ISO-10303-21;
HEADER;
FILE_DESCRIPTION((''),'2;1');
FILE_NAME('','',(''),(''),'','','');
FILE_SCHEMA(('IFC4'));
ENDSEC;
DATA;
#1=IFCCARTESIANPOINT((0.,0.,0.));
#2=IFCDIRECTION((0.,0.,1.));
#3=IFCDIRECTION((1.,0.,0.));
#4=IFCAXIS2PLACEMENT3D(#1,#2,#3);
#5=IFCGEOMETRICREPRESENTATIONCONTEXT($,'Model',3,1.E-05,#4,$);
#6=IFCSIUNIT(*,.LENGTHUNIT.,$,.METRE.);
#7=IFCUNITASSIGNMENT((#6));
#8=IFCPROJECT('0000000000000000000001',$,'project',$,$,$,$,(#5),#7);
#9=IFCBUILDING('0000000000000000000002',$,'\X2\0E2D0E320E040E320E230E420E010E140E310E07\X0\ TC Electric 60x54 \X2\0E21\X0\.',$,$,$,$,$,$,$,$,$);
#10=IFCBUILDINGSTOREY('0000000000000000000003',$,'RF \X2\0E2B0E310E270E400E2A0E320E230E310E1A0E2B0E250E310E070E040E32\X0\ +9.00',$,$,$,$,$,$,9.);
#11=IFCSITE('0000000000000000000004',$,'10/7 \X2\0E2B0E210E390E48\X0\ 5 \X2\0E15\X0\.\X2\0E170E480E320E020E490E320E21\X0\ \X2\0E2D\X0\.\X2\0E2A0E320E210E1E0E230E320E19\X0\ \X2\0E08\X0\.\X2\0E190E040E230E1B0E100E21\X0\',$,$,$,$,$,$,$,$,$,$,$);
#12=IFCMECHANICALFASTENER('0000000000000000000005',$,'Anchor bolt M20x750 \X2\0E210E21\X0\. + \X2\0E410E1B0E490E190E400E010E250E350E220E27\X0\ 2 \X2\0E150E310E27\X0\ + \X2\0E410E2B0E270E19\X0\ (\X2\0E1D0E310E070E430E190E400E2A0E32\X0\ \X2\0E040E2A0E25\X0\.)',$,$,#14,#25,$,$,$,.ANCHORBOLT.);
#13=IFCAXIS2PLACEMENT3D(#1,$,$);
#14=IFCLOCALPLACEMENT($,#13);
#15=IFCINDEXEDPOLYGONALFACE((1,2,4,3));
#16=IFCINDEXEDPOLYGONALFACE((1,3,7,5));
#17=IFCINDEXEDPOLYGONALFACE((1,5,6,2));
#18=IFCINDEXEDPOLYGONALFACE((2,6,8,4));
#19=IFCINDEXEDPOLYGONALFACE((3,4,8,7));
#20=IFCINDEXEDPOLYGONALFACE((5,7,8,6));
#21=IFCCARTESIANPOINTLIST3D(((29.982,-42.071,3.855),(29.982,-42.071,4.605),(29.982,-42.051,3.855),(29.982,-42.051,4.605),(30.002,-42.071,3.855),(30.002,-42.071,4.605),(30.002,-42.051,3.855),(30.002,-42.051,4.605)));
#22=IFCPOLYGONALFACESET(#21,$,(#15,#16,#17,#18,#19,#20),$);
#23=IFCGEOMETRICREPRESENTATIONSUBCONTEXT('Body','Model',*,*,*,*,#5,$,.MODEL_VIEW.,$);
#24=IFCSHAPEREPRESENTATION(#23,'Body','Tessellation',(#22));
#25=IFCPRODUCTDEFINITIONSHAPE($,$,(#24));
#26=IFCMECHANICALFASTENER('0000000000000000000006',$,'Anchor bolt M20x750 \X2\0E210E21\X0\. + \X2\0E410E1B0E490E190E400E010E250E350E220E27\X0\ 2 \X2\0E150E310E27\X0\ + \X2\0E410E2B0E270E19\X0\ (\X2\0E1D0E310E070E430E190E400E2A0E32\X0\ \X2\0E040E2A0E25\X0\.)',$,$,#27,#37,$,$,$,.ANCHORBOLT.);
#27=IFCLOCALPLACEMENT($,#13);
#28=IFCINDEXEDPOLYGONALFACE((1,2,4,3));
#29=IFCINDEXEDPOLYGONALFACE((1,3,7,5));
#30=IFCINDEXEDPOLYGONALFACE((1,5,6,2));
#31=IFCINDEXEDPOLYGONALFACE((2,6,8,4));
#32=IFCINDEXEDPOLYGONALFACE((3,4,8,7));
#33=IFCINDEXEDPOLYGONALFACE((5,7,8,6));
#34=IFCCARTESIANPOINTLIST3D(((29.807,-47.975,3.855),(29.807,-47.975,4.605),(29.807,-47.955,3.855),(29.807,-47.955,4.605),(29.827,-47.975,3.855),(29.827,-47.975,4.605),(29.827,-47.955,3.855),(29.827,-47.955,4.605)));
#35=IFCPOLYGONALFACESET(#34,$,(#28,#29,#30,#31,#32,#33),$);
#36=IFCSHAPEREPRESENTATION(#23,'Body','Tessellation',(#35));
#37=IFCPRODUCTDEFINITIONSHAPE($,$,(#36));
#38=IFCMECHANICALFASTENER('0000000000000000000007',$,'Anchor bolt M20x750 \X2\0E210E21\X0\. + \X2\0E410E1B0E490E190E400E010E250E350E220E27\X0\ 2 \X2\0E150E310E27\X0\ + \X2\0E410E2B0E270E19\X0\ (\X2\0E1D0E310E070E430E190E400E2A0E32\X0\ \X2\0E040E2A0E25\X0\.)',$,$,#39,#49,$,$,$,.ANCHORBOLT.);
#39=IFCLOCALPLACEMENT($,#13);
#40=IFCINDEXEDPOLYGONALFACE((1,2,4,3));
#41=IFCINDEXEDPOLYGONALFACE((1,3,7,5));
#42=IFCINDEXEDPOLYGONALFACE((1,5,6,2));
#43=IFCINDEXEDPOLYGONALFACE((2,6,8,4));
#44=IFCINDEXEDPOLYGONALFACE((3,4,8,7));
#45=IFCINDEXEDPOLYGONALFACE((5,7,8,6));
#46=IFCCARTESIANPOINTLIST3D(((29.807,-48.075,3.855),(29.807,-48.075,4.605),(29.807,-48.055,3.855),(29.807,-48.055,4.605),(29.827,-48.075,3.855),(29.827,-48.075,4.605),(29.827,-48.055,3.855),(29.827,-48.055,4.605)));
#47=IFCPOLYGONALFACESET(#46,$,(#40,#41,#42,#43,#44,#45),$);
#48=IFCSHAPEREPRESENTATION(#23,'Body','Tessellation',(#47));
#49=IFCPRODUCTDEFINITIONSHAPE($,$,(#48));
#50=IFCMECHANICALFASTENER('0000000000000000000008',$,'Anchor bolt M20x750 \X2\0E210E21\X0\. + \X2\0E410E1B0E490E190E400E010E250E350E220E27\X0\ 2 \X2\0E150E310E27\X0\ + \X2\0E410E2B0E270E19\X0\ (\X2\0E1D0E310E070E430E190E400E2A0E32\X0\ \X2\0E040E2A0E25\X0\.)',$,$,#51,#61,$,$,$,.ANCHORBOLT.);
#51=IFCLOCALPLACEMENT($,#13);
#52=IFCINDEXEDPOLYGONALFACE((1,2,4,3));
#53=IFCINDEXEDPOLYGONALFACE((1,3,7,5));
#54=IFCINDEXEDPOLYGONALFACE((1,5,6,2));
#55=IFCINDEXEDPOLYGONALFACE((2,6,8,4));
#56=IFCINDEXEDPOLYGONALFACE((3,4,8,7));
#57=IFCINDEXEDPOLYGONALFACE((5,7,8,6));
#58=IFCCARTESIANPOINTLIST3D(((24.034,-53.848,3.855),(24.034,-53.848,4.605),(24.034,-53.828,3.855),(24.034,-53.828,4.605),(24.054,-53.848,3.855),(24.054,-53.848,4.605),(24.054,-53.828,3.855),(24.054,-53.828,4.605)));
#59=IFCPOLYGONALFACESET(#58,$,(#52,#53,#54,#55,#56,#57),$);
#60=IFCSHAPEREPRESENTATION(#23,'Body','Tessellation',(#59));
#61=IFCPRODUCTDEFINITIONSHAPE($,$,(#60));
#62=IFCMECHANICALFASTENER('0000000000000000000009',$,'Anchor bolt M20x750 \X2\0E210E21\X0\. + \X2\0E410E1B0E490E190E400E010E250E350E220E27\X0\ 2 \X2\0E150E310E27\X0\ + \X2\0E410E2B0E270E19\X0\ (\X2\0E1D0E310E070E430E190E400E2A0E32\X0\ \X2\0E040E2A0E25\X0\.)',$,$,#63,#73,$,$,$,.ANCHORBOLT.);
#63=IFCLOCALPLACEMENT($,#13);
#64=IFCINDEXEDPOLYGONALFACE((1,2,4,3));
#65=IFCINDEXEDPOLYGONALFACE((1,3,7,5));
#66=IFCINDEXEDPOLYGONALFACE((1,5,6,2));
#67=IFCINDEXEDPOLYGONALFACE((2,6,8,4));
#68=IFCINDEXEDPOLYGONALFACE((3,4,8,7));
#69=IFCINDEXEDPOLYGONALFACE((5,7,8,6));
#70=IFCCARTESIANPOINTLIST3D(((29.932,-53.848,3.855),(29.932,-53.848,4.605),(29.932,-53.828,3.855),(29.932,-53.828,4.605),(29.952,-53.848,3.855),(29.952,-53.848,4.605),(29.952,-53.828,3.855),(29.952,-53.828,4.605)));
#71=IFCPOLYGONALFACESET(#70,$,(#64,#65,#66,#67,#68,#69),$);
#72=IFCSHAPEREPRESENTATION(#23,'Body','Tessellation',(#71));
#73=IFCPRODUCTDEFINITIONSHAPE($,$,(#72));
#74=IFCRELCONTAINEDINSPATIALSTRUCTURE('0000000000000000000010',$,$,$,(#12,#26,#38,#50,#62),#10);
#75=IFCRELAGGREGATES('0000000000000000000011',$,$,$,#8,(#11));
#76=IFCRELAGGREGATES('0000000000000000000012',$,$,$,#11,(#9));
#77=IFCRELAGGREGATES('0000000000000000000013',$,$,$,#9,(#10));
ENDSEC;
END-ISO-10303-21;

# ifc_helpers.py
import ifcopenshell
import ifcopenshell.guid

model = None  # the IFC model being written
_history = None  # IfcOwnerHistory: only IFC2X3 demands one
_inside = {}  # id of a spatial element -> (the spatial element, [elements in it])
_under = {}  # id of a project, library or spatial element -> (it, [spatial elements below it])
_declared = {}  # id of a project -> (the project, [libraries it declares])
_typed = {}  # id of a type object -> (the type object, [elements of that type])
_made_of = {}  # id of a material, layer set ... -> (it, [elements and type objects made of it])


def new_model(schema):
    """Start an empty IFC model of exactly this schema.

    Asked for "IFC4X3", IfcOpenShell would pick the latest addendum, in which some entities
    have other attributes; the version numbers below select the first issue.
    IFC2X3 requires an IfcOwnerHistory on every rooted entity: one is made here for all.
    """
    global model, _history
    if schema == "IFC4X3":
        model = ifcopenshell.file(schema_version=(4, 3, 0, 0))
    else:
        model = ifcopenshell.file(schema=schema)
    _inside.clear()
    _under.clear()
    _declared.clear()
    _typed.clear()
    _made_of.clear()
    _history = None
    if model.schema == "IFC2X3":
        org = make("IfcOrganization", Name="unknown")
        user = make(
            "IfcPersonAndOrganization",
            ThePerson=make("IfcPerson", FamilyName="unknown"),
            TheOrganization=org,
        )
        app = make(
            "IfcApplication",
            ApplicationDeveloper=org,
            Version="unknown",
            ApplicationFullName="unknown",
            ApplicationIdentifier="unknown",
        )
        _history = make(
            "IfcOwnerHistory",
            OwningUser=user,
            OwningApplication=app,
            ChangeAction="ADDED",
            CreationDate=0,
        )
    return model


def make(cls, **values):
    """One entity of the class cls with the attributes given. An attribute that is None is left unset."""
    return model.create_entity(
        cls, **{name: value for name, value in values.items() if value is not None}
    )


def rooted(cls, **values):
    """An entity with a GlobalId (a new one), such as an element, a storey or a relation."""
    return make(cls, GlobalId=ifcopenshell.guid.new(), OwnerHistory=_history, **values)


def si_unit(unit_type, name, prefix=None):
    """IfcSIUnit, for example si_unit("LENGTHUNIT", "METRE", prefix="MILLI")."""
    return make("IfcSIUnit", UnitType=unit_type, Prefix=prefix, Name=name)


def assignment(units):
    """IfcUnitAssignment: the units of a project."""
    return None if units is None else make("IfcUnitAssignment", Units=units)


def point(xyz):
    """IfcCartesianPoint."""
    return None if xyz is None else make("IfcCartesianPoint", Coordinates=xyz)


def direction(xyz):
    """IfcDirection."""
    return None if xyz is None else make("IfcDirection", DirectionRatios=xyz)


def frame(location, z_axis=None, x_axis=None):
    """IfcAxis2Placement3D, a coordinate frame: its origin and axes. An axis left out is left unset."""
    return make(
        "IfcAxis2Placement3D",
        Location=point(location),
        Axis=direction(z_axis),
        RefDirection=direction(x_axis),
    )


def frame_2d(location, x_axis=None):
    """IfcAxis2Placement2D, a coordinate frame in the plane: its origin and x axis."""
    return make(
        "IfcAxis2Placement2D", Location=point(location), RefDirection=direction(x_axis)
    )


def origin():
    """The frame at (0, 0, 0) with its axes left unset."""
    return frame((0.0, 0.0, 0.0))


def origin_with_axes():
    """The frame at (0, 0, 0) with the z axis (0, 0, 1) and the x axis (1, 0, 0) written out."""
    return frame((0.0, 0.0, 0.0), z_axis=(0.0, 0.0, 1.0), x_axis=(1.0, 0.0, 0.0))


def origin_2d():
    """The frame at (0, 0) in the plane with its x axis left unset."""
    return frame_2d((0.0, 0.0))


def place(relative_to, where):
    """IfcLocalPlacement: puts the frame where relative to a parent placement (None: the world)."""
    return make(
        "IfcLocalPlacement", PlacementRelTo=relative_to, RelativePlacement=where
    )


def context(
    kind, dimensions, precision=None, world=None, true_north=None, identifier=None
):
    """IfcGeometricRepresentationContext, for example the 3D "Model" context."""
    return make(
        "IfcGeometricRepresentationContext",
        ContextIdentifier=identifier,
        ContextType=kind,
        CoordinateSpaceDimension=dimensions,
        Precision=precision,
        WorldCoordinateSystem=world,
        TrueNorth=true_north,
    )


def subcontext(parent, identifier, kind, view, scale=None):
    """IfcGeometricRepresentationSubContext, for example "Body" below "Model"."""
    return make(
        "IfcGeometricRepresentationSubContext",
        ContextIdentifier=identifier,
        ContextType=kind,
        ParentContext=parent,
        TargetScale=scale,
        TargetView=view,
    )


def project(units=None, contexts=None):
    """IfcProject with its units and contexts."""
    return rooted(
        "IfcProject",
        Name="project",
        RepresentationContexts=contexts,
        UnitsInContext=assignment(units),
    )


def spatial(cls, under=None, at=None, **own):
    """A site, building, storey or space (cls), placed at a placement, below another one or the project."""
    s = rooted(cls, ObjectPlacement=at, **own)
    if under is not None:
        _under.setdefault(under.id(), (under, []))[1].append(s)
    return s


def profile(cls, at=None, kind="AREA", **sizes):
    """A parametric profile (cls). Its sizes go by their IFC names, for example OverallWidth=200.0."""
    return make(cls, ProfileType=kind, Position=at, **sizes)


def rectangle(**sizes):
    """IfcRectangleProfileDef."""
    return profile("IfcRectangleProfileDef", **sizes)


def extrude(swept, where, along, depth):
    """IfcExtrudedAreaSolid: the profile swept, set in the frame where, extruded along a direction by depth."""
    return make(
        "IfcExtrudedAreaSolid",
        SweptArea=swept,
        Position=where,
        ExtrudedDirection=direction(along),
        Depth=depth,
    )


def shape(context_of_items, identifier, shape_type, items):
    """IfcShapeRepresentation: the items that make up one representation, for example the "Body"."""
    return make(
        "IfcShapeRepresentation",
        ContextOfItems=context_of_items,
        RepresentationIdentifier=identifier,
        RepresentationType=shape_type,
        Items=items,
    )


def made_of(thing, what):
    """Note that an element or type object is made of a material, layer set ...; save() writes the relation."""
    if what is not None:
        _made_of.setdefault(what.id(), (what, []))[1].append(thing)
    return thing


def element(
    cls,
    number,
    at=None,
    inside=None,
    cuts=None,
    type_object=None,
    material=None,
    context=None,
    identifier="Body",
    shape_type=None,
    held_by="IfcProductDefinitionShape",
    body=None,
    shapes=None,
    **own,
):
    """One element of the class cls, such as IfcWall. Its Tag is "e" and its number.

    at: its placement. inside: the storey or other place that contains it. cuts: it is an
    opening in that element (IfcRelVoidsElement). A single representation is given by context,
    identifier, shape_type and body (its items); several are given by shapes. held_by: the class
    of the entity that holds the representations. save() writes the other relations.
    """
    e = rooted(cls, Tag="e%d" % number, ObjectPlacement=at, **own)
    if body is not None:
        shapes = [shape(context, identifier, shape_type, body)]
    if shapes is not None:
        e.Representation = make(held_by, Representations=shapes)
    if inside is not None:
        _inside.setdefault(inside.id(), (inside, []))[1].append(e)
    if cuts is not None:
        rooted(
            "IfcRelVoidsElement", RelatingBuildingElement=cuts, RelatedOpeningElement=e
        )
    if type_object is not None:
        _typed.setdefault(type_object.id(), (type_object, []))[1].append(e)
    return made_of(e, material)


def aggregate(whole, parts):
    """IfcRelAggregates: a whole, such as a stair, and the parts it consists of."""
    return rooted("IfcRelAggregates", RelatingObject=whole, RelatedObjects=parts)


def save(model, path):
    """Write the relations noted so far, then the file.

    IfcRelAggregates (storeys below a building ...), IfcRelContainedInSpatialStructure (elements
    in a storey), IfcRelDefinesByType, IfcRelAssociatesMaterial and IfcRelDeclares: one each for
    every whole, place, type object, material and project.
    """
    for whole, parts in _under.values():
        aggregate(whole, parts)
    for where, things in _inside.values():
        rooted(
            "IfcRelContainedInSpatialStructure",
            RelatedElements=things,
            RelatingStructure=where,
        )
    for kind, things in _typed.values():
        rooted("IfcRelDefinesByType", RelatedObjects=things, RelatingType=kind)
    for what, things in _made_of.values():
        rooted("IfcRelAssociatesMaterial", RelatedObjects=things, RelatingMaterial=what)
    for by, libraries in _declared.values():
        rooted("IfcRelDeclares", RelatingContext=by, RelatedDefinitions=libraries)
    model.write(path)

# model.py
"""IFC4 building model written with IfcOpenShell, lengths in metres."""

from ifc_helpers import new_model, si_unit, frame, origin, origin_with_axes, origin_2d, place, context, subcontext, project, spatial, rectangle, extrude, element, save


model = new_model("IFC4")

# Units and contexts
model_context = context("Model", 3, precision=1e-05, world=origin_with_axes())
body_context = subcontext(model_context, "Body", "Model", "MODEL_VIEW")
ifc_project = project(units=[si_unit("LENGTHUNIT", "METRE")], contexts=[model_context])

# Site, building, storey
site = spatial("IfcSite", under=ifc_project, Name="10/7 หมู่ 5 ต.ท่าข้าม อ.สามพราน จ.นครปฐม")
building = spatial("IfcBuilding", under=site, Name="อาคารโกดัง TC Electric 60x54 ม.")
storey = spatial("IfcBuildingStorey", under=building, Name="RF หัวเสารับหลังคา +9.00", Elevation=9.0)

# Mechanical fasteners
for number, where, z_axis, x_axis, name in (
    (1, (29.992, -42.061, 3.855), (0.0, 0.0, 1.0), (1.0, 0.0, 0.0), "Anchor bolt M20x750 มม. + แป้นเกลียว 2 ตัว + แหวน (ฝังในเสา คสล.)"),
    (2, (29.817, -47.965, 3.855), (0.0, 0.0, 1.0), (1.0, 0.0, 0.0), "Anchor bolt M20x750 มม. + แป้นเกลียว 2 ตัว + แหวน (ฝังในเสา คสล.)"),
    (3, (29.817, -48.065, 3.855), (0.0, 0.0, 1.0), (1.0, 0.0, 0.0), "Anchor bolt M20x750 มม. + แป้นเกลียว 2 ตัว + แหวน (ฝังในเสา คสล.)"),
    (4, (24.044, -53.838, 3.855), (0.0, 0.0, 1.0), (1.0, 0.0, 0.0), "Anchor bolt M20x750 มม. + แป้นเกลียว 2 ตัว + แหวน (ฝังในเสา คสล.)"),
    (5, (29.942, -53.838, 3.855), (0.0, 0.0, 1.0), (1.0, 0.0, 0.0), "Anchor bolt M20x750 มม. + แป้นเกลียว 2 ตัว + แหวน (ฝังในเสา คสล.)"),
):
    element("IfcMechanicalFastener", number, at=place(None, frame(where, z_axis=z_axis, x_axis=x_axis)), inside=storey, Name=name, PredefinedType="ANCHORBOLT", context=body_context, shape_type="SweptSolid", body=[
        extrude(rectangle(XDim=0.02, YDim=0.02, at=origin_2d()), origin(), (0.0, 0.0, 1.0), 0.75),
    ])

save(model, "model.ifc")
